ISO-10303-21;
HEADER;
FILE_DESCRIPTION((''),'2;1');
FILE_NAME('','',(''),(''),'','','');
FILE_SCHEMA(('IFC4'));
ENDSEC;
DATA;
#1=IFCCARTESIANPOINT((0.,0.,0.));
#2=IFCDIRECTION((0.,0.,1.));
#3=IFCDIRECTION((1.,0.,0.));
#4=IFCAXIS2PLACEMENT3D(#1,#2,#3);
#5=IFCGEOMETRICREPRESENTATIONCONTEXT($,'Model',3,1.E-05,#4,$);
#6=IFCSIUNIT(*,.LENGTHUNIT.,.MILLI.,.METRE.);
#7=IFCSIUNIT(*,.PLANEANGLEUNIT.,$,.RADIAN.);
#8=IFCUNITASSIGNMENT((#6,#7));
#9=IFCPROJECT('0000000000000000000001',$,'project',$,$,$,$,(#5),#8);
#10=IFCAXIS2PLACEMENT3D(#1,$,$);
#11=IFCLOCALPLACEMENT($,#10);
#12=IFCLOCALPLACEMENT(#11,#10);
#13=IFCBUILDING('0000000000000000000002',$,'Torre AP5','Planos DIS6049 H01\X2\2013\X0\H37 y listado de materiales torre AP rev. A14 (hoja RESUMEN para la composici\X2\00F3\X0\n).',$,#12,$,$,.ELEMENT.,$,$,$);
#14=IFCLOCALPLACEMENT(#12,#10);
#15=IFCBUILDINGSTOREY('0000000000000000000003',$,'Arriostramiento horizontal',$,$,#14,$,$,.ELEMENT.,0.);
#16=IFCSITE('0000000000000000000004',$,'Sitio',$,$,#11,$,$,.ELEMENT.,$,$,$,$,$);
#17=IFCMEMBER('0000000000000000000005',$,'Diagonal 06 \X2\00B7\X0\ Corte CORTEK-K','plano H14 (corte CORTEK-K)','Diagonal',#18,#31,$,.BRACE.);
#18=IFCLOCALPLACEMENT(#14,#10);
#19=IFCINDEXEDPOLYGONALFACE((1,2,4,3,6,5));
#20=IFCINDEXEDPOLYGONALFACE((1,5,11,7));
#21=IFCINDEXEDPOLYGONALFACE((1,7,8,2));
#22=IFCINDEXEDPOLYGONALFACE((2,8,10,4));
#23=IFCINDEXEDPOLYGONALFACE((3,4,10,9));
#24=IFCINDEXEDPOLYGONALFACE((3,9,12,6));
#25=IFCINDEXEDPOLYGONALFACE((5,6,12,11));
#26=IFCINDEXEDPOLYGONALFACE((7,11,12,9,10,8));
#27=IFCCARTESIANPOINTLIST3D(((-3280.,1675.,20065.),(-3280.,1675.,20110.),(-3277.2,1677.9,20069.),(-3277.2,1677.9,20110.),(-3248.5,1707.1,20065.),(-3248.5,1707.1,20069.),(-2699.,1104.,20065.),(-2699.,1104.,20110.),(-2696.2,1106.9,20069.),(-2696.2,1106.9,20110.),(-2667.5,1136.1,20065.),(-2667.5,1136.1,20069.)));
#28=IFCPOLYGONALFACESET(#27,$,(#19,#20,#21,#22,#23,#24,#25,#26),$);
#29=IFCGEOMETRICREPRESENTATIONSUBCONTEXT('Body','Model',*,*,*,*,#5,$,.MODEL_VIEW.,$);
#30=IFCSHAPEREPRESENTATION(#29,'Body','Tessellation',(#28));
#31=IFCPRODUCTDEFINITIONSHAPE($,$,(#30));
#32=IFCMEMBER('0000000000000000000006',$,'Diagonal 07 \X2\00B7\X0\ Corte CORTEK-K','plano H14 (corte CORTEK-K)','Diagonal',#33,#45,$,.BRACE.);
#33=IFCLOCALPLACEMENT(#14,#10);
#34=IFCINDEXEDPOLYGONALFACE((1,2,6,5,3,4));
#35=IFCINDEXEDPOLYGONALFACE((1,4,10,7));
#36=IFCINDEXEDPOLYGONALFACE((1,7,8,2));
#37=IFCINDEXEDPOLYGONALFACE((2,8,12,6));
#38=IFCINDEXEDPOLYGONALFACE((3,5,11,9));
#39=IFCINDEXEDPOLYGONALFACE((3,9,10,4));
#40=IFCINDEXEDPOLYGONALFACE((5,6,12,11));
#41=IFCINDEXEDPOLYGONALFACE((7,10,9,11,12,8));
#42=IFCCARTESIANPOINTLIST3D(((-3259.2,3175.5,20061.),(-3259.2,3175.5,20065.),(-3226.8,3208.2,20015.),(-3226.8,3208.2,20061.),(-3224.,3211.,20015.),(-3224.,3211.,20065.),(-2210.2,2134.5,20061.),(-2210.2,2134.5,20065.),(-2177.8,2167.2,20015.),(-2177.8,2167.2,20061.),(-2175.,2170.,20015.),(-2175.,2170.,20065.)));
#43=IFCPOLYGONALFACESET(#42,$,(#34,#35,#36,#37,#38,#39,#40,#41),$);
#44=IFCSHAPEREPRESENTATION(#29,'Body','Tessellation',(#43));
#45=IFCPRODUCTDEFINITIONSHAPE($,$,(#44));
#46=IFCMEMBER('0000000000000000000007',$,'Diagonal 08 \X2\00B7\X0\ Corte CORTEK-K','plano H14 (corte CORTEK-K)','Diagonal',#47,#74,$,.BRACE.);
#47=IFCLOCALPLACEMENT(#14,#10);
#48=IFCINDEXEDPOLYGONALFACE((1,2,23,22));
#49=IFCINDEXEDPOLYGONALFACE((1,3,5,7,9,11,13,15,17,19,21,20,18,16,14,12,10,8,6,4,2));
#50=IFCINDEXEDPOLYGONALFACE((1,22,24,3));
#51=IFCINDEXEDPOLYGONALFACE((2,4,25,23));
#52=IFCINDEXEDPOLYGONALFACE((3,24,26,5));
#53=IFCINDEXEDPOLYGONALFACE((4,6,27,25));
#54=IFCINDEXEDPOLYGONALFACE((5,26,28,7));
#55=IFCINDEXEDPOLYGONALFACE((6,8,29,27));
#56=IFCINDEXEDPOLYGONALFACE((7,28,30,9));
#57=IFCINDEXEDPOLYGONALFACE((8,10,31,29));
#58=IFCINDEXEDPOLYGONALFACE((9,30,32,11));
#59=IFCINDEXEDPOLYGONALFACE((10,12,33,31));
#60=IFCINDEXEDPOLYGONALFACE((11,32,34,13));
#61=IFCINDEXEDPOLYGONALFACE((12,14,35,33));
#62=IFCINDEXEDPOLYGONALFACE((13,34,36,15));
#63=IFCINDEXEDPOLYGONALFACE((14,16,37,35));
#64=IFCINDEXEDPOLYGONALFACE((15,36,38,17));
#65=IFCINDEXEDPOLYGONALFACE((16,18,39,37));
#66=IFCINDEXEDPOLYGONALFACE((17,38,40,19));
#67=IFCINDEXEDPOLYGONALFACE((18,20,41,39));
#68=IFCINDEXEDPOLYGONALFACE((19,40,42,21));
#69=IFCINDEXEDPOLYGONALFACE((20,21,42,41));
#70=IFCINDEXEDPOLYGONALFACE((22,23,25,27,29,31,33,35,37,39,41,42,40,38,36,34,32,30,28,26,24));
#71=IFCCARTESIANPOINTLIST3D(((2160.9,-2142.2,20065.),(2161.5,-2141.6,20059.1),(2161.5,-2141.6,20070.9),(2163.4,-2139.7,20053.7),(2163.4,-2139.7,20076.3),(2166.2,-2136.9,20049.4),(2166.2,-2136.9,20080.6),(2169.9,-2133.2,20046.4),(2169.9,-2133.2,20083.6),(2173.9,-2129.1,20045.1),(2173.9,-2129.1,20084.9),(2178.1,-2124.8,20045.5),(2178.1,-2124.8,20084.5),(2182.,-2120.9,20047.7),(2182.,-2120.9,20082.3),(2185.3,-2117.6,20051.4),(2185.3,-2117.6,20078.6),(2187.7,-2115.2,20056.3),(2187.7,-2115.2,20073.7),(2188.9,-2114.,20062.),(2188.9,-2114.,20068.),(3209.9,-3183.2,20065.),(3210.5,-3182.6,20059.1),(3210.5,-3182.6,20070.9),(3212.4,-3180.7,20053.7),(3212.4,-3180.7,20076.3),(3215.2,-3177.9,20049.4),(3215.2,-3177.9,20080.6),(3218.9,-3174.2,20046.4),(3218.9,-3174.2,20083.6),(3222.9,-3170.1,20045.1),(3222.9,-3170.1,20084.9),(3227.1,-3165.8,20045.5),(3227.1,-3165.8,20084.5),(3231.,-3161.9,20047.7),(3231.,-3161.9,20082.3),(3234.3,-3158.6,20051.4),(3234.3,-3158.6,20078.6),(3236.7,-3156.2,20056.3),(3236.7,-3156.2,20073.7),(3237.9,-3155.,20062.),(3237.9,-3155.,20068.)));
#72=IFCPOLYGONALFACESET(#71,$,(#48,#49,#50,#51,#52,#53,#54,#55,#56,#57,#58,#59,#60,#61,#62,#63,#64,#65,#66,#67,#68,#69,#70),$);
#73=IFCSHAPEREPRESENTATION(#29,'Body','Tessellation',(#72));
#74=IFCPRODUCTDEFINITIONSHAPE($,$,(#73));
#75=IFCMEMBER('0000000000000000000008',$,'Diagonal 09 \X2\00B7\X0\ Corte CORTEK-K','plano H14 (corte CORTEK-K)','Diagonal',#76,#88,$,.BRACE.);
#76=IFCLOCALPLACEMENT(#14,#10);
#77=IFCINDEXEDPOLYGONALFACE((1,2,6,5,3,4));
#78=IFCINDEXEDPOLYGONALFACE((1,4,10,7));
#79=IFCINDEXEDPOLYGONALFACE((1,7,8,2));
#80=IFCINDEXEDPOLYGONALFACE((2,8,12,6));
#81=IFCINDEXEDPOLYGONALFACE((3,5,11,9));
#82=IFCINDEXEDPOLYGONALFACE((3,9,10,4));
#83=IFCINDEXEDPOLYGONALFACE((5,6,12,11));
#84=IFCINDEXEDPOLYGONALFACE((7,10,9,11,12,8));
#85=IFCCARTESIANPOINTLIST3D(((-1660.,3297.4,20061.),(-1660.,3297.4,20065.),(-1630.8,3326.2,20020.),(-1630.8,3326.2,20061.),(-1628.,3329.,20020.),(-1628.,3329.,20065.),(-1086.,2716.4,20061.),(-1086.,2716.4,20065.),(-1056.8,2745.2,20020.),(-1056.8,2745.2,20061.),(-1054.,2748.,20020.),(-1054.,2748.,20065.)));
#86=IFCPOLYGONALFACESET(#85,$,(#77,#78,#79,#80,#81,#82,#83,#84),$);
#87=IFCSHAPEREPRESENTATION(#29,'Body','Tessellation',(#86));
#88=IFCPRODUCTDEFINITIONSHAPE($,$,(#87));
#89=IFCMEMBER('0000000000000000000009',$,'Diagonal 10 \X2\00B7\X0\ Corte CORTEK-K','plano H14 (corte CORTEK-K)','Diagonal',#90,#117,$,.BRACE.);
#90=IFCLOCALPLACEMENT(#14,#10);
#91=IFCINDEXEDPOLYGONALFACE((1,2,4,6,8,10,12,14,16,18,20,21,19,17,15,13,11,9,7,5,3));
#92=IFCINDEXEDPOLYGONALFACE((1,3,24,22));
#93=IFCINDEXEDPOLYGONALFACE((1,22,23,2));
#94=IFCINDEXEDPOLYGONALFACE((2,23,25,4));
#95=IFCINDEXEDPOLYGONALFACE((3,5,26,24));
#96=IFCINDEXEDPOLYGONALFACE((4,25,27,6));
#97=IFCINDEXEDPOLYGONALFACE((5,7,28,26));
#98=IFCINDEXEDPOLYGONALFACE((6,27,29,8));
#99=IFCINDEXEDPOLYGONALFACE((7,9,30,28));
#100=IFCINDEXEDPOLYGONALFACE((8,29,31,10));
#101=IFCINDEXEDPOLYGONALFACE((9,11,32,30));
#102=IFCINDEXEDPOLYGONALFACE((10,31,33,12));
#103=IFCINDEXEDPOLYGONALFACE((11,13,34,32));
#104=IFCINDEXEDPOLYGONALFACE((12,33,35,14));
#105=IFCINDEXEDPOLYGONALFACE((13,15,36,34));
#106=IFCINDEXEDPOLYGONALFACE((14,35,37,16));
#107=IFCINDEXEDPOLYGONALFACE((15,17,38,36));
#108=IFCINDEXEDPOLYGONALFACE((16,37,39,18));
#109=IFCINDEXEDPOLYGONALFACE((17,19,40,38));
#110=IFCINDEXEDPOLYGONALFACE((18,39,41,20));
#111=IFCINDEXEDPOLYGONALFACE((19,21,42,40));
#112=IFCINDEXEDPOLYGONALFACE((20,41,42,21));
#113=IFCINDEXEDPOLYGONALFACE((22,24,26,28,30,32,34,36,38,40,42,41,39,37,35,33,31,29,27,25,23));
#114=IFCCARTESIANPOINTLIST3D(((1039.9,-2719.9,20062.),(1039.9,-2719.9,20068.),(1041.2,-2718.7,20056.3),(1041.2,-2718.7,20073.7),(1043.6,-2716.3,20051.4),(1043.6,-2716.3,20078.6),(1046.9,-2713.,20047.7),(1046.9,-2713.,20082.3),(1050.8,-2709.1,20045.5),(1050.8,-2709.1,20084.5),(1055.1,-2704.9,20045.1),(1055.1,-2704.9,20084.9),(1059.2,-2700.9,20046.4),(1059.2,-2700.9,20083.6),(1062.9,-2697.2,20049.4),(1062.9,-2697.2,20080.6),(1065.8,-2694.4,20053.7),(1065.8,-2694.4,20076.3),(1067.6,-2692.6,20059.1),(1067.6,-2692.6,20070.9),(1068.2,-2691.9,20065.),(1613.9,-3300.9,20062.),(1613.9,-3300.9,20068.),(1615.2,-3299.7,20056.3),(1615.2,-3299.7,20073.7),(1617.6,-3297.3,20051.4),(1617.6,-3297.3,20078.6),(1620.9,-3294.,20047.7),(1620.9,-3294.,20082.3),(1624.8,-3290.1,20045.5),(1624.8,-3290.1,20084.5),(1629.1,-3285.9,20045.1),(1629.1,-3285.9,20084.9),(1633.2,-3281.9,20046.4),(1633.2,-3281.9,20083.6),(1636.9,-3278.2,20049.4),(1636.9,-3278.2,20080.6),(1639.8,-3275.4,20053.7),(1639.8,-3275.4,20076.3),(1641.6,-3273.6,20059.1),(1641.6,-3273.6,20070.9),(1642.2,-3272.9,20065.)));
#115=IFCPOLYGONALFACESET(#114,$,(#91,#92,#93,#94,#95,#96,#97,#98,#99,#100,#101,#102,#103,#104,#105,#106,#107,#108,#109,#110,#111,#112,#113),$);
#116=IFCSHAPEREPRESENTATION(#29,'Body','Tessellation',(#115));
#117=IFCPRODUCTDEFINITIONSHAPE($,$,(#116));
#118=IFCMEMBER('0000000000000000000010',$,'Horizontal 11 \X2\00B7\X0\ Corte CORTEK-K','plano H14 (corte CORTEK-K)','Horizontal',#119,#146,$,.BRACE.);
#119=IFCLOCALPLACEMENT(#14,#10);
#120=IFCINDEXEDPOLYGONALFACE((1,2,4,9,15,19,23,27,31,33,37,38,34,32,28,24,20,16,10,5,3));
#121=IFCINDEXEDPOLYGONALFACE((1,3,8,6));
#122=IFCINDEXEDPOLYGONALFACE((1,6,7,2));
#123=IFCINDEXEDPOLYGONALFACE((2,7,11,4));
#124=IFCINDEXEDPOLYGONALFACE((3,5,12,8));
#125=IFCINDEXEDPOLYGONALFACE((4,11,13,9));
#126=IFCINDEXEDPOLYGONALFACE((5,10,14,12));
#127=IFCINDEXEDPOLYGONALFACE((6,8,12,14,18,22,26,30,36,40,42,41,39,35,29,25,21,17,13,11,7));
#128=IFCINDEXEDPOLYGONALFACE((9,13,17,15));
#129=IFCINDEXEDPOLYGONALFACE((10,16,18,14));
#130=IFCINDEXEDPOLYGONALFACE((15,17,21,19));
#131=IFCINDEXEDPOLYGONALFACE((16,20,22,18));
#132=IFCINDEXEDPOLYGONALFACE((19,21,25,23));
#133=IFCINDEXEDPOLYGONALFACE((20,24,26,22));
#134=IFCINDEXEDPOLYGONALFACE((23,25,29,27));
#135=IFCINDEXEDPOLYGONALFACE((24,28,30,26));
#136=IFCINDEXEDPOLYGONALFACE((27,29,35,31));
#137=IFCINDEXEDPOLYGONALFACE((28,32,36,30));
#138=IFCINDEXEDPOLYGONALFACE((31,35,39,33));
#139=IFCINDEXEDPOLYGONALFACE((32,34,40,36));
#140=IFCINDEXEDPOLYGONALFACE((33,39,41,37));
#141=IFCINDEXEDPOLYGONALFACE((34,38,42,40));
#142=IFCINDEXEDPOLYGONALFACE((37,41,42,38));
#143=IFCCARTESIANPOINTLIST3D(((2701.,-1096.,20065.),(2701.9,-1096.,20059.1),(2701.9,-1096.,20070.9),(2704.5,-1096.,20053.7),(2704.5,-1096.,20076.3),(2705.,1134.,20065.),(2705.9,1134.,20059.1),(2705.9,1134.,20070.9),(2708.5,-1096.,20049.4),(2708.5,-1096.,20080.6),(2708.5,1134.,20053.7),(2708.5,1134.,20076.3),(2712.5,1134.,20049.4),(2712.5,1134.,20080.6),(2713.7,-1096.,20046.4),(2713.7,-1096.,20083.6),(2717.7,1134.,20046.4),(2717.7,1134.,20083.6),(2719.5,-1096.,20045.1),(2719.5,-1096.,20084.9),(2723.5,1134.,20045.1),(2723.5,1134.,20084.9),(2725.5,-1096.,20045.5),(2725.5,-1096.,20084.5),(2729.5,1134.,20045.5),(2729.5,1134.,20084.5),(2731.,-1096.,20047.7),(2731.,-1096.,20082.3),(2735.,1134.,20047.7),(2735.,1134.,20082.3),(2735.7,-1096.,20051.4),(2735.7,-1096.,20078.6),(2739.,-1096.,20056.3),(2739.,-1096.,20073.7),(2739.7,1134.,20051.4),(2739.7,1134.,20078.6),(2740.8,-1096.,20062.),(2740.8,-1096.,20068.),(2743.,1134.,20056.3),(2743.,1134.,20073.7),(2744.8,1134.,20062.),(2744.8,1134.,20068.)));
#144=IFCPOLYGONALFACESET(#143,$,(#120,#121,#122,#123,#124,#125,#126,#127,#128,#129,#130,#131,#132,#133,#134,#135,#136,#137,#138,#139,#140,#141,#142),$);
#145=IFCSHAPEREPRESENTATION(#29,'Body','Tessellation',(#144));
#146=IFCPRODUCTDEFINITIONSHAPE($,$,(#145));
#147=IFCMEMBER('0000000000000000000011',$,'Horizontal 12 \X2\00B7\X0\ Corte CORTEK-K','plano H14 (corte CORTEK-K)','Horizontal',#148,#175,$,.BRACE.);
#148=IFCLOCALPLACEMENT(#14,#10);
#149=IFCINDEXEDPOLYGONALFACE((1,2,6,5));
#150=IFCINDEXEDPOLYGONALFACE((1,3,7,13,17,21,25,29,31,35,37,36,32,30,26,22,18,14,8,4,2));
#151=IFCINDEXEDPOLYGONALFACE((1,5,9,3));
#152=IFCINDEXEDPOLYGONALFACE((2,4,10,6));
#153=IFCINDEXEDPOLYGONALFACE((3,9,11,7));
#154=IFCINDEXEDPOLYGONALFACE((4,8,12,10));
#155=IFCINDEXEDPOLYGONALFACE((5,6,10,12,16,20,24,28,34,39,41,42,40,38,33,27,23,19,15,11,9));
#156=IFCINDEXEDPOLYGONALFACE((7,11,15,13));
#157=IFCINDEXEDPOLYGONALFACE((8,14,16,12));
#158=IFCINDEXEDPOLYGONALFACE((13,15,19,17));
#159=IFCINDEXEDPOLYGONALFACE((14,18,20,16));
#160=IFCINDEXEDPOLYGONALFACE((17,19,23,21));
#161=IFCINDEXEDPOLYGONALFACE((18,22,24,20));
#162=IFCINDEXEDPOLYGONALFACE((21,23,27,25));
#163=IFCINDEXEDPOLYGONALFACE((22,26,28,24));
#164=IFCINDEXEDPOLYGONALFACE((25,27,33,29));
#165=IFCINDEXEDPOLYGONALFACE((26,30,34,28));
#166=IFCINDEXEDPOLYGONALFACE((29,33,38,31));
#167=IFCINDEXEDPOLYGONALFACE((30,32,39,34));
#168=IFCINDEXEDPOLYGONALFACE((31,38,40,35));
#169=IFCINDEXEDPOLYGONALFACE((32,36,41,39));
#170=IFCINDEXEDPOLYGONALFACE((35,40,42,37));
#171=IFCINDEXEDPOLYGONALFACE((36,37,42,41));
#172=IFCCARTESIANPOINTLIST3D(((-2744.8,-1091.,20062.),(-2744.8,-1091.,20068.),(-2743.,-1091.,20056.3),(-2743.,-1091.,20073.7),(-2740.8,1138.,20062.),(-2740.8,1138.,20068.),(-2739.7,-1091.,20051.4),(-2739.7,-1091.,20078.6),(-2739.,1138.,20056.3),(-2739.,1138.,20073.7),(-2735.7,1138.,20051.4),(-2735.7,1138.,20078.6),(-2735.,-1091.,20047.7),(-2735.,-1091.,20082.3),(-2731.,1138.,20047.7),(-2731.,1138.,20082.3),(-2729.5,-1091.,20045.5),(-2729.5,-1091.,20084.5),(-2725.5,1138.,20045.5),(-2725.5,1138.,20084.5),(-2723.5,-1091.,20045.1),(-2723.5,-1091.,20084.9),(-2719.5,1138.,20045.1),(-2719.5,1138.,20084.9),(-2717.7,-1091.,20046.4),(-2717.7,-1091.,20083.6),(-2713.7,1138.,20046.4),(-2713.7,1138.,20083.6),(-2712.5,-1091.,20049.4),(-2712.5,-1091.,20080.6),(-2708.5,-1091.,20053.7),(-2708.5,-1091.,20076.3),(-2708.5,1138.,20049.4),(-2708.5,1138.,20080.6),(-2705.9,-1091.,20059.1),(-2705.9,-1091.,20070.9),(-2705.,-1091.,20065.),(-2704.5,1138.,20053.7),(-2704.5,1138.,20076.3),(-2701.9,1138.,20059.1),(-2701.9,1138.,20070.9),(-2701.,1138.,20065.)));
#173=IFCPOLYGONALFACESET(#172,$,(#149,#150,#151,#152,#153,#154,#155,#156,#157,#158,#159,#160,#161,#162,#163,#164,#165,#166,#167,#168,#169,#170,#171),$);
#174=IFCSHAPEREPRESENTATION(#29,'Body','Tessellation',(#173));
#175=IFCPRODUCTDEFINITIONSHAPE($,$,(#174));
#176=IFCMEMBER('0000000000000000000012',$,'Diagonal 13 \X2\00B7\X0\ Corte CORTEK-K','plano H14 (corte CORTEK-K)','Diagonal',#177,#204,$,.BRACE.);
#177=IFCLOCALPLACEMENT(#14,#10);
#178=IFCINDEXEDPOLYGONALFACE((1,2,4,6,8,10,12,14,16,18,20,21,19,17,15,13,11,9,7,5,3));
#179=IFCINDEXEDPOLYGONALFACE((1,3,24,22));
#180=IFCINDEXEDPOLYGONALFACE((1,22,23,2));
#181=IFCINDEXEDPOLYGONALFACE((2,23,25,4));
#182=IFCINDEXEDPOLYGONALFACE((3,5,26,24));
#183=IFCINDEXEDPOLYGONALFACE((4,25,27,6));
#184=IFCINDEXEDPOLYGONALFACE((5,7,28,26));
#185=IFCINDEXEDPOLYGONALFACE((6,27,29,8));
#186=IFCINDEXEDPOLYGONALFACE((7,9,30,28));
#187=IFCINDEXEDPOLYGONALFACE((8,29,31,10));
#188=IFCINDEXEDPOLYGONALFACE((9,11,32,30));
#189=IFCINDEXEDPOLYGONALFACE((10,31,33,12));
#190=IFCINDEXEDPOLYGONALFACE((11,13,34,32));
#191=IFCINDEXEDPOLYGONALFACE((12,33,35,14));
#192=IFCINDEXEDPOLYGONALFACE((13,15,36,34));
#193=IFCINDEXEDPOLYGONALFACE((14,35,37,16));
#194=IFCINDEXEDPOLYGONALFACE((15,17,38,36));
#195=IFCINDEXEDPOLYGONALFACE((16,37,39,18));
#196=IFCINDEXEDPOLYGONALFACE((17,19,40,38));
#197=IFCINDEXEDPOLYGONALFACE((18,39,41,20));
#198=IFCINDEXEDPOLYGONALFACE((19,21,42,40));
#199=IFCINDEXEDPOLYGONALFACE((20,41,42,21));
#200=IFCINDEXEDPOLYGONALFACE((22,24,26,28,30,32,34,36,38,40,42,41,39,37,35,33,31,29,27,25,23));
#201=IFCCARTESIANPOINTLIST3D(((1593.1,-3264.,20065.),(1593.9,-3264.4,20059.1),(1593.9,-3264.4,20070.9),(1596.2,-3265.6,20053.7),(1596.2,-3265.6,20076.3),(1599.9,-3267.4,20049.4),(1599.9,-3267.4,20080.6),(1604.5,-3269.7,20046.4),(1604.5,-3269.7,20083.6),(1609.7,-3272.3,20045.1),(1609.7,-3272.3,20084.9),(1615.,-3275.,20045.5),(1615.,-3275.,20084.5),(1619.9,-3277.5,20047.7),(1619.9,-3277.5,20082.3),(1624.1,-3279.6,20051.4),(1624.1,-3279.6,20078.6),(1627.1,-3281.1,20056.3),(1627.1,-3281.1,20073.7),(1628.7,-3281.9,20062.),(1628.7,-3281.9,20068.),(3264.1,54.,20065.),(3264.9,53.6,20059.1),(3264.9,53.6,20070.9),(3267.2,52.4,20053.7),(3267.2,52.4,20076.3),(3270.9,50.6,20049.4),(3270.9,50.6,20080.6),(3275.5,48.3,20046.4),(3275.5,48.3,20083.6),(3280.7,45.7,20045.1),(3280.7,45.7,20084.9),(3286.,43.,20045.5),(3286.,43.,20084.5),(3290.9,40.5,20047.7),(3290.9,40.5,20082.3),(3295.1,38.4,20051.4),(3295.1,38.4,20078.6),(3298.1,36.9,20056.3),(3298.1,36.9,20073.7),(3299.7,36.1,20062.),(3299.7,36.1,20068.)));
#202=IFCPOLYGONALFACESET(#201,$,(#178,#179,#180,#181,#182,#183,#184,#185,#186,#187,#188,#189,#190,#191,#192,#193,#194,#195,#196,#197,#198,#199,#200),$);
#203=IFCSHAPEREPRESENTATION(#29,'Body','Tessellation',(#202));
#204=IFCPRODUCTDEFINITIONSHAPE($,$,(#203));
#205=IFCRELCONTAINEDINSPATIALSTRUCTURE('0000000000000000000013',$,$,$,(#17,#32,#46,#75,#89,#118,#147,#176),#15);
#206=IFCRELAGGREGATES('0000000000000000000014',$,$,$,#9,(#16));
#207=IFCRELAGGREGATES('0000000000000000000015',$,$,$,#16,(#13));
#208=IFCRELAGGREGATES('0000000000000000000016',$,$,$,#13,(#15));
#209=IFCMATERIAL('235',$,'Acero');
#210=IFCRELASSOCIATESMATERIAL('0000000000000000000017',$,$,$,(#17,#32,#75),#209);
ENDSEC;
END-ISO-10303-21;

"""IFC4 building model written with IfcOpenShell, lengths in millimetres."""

from ifc_helpers import new_model, si_unit, frame, frame_2d, origin, origin_with_axes, place, context, subcontext, project, spatial, circle, l_section, extrude, material, element, save


model = new_model("IFC4")

# Units and contexts
model_context = context("Model", 3, precision=1e-05, world=origin_with_axes())
body_context = subcontext(model_context, "Body", "Model", "MODEL_VIEW")
ifc_project = project(units=[si_unit("LENGTHUNIT", "METRE", prefix="MILLI"), si_unit("PLANEANGLEUNIT", "RADIAN")], contexts=[model_context])

# Site, building, storey
site_placement = place(None, origin())
site = spatial("IfcSite", under=ifc_project, at=site_placement, Name="Sitio", CompositionType="ELEMENT")
building_placement = place(site_placement, origin())
building = spatial("IfcBuilding", under=site, at=building_placement, Name="Torre AP5", Description="Planos DIS6049 H01–H37 y listado de materiales torre AP rev. A14 (hoja RESUMEN para la composición).", CompositionType="ELEMENT")
storey_placement = place(building_placement, origin())
storey = spatial("IfcBuildingStorey", under=building, at=storey_placement, Name="Arriostramiento horizontal", CompositionType="ELEMENT", Elevation=0.0)

# Members
ifc_material = material(Name="235", Category="Acero")
member_1_placement = place(storey_placement, frame((-3280.0, 1675.0, 20065.0), z_axis=(0.713218, -0.700942, 0.0), x_axis=(0.700942, 0.713218, 0.0)))
element("IfcMember", 1, at=member_1_placement, inside=storey, material=ifc_material, Name="Diagonal 06 · Corte CORTEK-K", Description="plano H14 (corte CORTEK-K)", ObjectType="Diagonal", PredefinedType="BRACE", context=body_context, shape_type="SweptSolid", body=[
    extrude(l_section(Depth=45.0, Width=45.0, Thickness=4.0, at=frame_2d((22.5, 22.5))), None, (0.0, 0.0, 1.0), 814.6),
])
member_2_placement = place(storey_placement, frame((-3224.0, 3211.0, 20065.0), z_axis=(0.709808, -0.704395, 0.0), x_axis=(-0.704395, -0.709808, 0.0)))
element("IfcMember", 2, at=member_2_placement, inside=storey, material=ifc_material, Name="Diagonal 07 · Corte CORTEK-K", Description="plano H14 (corte CORTEK-K)", ObjectType="Diagonal", PredefinedType="BRACE", context=body_context, shape_type="SweptSolid", body=[
    extrude(l_section(Depth=50.0, Width=50.0, Thickness=4.0, at=frame_2d((25.0, 25.0))), None, (0.0, 0.0, 1.0), 1477.9),
])
member_3_placement = place(storey_placement, frame((2175.0, -2128.0, 20065.0), z_axis=(0.709808, -0.704395, 0.0), x_axis=(-0.704395, -0.709808, 0.0)))
element("IfcMember", 3, at=member_3_placement, inside=storey, Name="Diagonal 08 · Corte CORTEK-K", Description="plano H14 (corte CORTEK-K)", ObjectType="Diagonal", PredefinedType="BRACE", context=body_context, shape_type="SweptSolid", body=[
    extrude(circle(Radius=20.0), None, (0.0, 0.0, 1.0), 1477.9),
])
member_4_placement = place(storey_placement, frame((-1628.0, 3329.0, 20065.0), z_axis=(0.702808, -0.711379, 0.0), x_axis=(-0.711379, -0.702808, 0.0)))
element("IfcMember", 4, at=member_4_placement, inside=storey, material=ifc_material, Name="Diagonal 09 · Corte CORTEK-K", Description="plano H14 (corte CORTEK-K)", ObjectType="Diagonal", PredefinedType="BRACE", context=body_context, shape_type="SweptSolid", body=[
    extrude(l_section(Depth=45.0, Width=45.0, Thickness=4.0, at=frame_2d((22.5, 22.5))), None, (0.0, 0.0, 1.0), 816.7),
])
member_5_placement = place(storey_placement, frame((1054.0, -2706.0, 20065.0), z_axis=(0.702808, -0.711379, 0.0), x_axis=(0.711379, 0.702808, 0.0)))
element("IfcMember", 5, at=member_5_placement, inside=storey, Name="Diagonal 10 · Corte CORTEK-K", Description="plano H14 (corte CORTEK-K)", ObjectType="Diagonal", PredefinedType="BRACE", context=body_context, shape_type="SweptSolid", body=[
    extrude(circle(Radius=20.0), None, (0.0, 0.0, 1.0), 816.7),
])
member_6_placement = place(storey_placement, frame((2725.0, 1134.0, 20065.0), z_axis=(-0.001794, -0.999998, 0.0), x_axis=(-0.999998, 0.001794, 0.0)))
element("IfcMember", 6, at=member_6_placement, inside=storey, Name="Horizontal 11 · Corte CORTEK-K", Description="plano H14 (corte CORTEK-K)", ObjectType="Horizontal", PredefinedType="BRACE", context=body_context, shape_type="SweptSolid", body=[
    extrude(circle(Radius=20.0), None, (0.0, 0.0, 1.0), 2230.0),
])
member_7_placement = place(storey_placement, frame((-2721.0, 1138.0, 20065.0), z_axis=(-0.001795, -0.999998, 0.0), x_axis=(0.999998, -0.001795, 0.0)))
element("IfcMember", 7, at=member_7_placement, inside=storey, Name="Horizontal 12 · Corte CORTEK-K", Description="plano H14 (corte CORTEK-K)", ObjectType="Horizontal", PredefinedType="BRACE", context=body_context, shape_type="SweptSolid", body=[
    extrude(circle(Radius=20.0), None, (0.0, 0.0, 1.0), 2229.0),
])
member_8_placement = place(storey_placement, frame((3282.0, 45.0, 20065.0), z_axis=(-0.449796, -0.893131, 0.0), x_axis=(-0.893131, 0.449796, 0.0)))
element("IfcMember", 8, at=member_8_placement, inside=storey, Name="Diagonal 13 · Corte CORTEK-K", Description="plano H14 (corte CORTEK-K)", ObjectType="Diagonal", PredefinedType="BRACE", context=body_context, shape_type="SweptSolid", body=[
    extrude(circle(Radius=20.0), None, (0.0, 0.0, 1.0), 3715.0),
])

save(model, "model.ifc")
